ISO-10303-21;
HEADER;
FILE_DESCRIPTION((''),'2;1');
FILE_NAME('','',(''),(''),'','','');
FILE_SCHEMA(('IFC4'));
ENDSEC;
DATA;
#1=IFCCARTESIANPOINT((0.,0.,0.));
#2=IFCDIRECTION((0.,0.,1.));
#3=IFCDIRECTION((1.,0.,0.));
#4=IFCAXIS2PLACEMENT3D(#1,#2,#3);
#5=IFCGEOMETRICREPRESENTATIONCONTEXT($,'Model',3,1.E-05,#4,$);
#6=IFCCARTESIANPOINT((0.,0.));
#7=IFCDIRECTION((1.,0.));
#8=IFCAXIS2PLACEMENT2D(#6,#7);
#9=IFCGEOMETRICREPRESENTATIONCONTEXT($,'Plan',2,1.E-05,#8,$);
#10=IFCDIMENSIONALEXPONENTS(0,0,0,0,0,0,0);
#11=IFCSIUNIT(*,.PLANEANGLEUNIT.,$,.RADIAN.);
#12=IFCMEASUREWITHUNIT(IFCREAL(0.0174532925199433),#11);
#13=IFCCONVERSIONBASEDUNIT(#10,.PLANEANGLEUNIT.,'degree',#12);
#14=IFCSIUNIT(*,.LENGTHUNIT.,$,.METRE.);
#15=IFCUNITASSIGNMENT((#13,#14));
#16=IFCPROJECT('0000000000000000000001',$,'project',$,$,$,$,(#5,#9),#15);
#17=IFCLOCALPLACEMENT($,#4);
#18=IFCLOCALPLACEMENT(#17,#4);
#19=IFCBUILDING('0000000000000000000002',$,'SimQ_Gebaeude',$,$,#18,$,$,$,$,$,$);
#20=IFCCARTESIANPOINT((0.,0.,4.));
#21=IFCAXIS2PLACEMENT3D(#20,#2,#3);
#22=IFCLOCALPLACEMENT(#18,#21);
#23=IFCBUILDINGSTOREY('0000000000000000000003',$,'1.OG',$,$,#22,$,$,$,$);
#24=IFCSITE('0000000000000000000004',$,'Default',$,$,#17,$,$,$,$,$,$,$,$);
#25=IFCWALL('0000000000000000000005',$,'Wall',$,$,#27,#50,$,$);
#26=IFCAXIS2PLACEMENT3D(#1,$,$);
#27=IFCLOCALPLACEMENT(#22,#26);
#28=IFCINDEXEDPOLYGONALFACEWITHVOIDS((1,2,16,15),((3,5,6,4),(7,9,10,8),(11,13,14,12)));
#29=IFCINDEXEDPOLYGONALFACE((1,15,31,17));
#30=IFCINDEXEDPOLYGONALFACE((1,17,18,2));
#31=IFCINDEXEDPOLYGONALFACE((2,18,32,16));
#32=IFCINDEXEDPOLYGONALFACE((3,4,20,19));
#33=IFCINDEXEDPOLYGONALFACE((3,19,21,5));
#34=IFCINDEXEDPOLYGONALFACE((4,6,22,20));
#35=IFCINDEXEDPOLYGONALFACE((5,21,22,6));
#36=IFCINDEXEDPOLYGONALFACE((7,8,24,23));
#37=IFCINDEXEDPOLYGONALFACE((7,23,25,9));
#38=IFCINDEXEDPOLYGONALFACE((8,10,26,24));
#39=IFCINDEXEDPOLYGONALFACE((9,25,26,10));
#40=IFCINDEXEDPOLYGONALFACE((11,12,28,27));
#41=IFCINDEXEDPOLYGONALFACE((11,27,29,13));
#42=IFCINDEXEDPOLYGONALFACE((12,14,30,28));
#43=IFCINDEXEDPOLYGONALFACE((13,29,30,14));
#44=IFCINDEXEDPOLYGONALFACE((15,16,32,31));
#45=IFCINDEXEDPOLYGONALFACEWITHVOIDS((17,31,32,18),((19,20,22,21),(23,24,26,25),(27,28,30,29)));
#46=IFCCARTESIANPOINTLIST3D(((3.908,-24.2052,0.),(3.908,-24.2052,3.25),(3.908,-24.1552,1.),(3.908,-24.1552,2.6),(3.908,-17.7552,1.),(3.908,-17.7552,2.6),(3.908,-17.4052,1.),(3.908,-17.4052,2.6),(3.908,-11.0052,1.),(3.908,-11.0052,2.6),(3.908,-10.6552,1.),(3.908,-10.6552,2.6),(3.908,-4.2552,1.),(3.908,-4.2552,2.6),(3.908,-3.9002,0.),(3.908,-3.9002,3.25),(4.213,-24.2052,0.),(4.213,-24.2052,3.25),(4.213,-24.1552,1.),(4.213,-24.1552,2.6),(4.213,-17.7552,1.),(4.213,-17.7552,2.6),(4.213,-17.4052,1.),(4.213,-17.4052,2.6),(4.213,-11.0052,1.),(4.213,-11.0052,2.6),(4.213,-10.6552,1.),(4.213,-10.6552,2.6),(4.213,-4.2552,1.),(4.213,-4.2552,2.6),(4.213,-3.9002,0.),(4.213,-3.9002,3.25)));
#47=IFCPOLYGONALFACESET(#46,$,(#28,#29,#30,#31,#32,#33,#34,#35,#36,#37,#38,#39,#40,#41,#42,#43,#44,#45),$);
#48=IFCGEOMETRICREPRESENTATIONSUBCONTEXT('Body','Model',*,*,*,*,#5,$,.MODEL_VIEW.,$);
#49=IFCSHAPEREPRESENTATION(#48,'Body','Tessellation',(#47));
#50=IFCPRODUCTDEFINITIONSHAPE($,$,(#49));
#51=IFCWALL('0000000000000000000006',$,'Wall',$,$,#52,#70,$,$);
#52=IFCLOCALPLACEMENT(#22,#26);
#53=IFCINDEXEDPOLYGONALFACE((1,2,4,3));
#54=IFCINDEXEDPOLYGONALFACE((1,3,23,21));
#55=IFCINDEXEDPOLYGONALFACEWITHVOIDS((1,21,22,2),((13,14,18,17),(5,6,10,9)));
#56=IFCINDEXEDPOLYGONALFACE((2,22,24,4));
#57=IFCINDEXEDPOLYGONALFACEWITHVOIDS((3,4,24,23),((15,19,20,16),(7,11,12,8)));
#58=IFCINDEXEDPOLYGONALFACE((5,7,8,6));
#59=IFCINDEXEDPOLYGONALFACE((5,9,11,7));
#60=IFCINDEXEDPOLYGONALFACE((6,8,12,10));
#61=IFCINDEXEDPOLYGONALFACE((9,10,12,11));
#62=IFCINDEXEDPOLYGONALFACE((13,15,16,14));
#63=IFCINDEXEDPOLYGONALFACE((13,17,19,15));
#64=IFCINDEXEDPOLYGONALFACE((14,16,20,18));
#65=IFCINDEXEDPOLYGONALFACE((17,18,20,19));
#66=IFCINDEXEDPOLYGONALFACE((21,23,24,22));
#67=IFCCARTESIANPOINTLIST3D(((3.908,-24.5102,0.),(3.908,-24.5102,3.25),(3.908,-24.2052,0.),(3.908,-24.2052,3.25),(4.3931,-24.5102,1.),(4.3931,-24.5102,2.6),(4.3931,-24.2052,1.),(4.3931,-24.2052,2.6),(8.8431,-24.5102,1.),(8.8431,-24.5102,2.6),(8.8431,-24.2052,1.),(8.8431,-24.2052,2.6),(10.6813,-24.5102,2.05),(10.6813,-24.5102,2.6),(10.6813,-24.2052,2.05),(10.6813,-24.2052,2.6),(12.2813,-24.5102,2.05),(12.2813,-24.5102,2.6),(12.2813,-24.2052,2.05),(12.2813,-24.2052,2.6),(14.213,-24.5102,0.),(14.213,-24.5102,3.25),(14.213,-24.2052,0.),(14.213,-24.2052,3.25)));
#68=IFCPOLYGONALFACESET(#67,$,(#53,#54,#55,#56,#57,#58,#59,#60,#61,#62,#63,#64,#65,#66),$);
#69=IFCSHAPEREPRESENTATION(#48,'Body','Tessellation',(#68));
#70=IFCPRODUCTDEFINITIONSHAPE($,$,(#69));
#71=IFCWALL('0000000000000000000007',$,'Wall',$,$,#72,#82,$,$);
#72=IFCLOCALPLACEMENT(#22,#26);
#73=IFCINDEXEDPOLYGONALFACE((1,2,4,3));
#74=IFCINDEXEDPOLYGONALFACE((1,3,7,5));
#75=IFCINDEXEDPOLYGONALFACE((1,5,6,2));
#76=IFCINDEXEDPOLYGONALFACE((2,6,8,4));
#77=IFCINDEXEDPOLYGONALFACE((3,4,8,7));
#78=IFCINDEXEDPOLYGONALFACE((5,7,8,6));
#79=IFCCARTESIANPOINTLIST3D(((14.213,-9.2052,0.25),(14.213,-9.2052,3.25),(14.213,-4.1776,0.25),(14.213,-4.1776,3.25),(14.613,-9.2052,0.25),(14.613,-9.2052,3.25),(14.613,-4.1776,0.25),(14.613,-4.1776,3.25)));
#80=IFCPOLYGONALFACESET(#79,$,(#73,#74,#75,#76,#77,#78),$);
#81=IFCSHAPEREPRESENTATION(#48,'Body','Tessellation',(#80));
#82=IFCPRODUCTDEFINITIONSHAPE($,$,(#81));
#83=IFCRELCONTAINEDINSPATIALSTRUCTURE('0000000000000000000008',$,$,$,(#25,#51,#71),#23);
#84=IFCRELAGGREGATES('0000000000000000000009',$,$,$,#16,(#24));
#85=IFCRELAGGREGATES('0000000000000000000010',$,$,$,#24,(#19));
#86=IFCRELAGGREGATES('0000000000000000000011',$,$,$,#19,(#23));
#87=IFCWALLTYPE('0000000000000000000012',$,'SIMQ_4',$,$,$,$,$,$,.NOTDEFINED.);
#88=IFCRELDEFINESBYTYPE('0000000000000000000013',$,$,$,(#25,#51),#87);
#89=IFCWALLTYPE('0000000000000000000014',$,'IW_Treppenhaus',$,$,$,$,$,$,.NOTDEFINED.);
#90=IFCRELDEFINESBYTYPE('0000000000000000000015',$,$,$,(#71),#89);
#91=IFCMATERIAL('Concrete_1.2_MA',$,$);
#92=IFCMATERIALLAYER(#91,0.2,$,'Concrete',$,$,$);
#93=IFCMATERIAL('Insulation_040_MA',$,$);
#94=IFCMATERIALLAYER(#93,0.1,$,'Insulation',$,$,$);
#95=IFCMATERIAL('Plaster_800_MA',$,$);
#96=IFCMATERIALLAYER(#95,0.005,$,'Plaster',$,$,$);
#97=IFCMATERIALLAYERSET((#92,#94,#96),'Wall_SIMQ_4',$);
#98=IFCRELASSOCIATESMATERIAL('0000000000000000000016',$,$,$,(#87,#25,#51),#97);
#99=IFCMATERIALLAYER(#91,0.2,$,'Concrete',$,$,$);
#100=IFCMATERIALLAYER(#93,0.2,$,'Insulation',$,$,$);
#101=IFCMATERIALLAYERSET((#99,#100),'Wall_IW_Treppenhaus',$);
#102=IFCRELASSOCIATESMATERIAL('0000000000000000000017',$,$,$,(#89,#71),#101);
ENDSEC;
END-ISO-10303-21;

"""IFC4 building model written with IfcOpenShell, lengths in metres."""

from ifc_helpers import new_model, entity, si_unit, converted_unit, frame, origin_with_axes, origin_2d_with_axis, place, context, subcontext, project, spatial, line, indexed_curve, outline, extrude, source, transform, mapped, material, layer, layer_set, layer_usage, type_object, element, save


model = new_model("IFC4")

# Units and contexts
model_context = context("Model", 3, precision=1e-05, world=origin_with_axes())
plan_context = context("Plan", 2, precision=1e-05, world=origin_2d_with_axis())
body_context = subcontext(model_context, "Body", "Model", "MODEL_VIEW")
ifc_project = project(units=[converted_unit("PLANEANGLEUNIT", "degree", entity("IfcReal", 0.0174532925199433), si_unit("PLANEANGLEUNIT", "RADIAN"), dimensions=[0, 0, 0, 0, 0, 0, 0]), si_unit("LENGTHUNIT", "METRE")], contexts=[model_context, plan_context])

# Site, building, storey
site_placement = place(None, origin_with_axes())
site = spatial("IfcSite", under=ifc_project, at=site_placement, Name="Default")
building_placement = place(site_placement, origin_with_axes())
building = spatial("IfcBuilding", under=site, at=building_placement, Name="SimQ_Gebaeude")
storey_placement = place(building_placement, frame((0.0, 0.0, 4.0), z_axis=(0.0, 0.0, 1.0), x_axis=(1.0, 0.0, 0.0)))
storey = spatial("IfcBuildingStorey", under=building, at=storey_placement, Name="1.OG")

# Shared definitions
ifc_material_1 = material(Name="Insulation_040_MA")
ifc_material_2 = material(Name="Concrete_1.2_MA")

# Walls, openings
ifc_layer_1 = layer(ifc_material_2, 0.2, Name="Concrete")
ifc_layer_2 = layer(ifc_material_1, 0.1, Name="Insulation")
ifc_material_3 = material(Name="Plaster_800_MA")
ifc_layer_3 = layer(ifc_material_3, 0.005, Name="Plaster")
ifc_layer_set_1 = layer_set([ifc_layer_1, ifc_layer_2, ifc_layer_3], Name="Wall_SIMQ_4")
wall_type_1 = type_object("IfcWallType", Name="SIMQ_4", PredefinedType="NOTDEFINED", material=ifc_layer_set_1)
shared_shape_1 = source(origin_with_axes(), body_context, "Body", "SweptSolid", [
    extrude(outline(indexed_curve([(0.0, 0.0), (1.6, 0.0), (1.6, 0.55), (0.0, 0.55)], segments=[line(1, 2, 3, 4, 1)])), frame((0.0, -0.6, 0.0), z_axis=(0.0, -1.0, 0.0), x_axis=(1.0, 0.0, 0.0)), (0.0, 0.0, -1.0), 1.2),
])
shared_shape_2 = source(origin_with_axes(), body_context, "Body", "SweptSolid", [
    extrude(outline(indexed_curve([(0.0, 0.0), (4.45, 0.0), (4.45, 1.6), (0.0, 1.6)], segments=[line(1, 2, 3, 4, 1)])), frame((0.0, -0.6, 0.0), z_axis=(0.0, -1.0, 0.0), x_axis=(1.0, 0.0, 0.0)), (0.0, 0.0, -1.0), 1.2),
])
ifc_layer_usage_1 = layer_usage(ifc_layer_set_1, "AXIS2", "POSITIVE", 0.0)
wall_1_placement = place(storey_placement, frame((3.908, -3.9002, 0.0), z_axis=(0.0, 0.0, 1.0), x_axis=(-0.000001, -1.0, 0.0)))
wall_1 = element("IfcWall", 1, at=wall_1_placement, inside=storey, type_object=wall_type_1, material=ifc_layer_usage_1, Name="Wall", context=body_context, shape_type="SweptSolid", body=[
    extrude(outline(indexed_curve([(0.0, 0.0), (0.0, 0.305), (20.305, 0.305), (20.305, 0.0), (0.0, 0.0)], self_intersect=False)), origin_with_axes(), (0.0, 0.0, 1.0), 3.25),
])
shared_shape_3 = source(origin_with_axes(), body_context, "Body", "SweptSolid", [
    extrude(outline(indexed_curve([(0.0, 0.0), (6.4, 0.0), (6.4, 1.6), (0.0, 1.6)], segments=[line(1, 2, 3, 4, 1)])), frame((0.0, -0.6, 0.0), z_axis=(0.0, -1.0, 0.0), x_axis=(1.0, 0.0, 0.0)), (0.0, 0.0, -1.0), 1.2),
])
opening_1_placement = place(wall_1_placement, frame((0.355, 0.0, 1.0), z_axis=(0.0, 0.0, 1.0), x_axis=(1.0, 0.0, 0.0)))
element("IfcOpeningElement", 2, at=opening_1_placement, cuts=wall_1, PredefinedType="OPENING", context=body_context, shape_type="MappedRepresentation", body=[
    mapped(shared_shape_3, transform((0.0, 0.0, 0.0), x_axis=(1.0, 0.0, 0.0), y_axis=(0.0, 1.0, 0.0), z_axis=(0.0, 0.0, 1.0), scale=1.0)),
])
opening_2_placement = place(wall_1_placement, frame((7.105, 0.0, 1.0), z_axis=(0.0, 0.0, 1.0), x_axis=(1.0, 0.0, 0.0)))
element("IfcOpeningElement", 3, at=opening_2_placement, cuts=wall_1, PredefinedType="OPENING", context=body_context, shape_type="MappedRepresentation", body=[
    mapped(shared_shape_3, transform((0.0, 0.0, 0.0), x_axis=(1.0, 0.0, 0.0), y_axis=(0.0, 1.0, 0.0), z_axis=(0.0, 0.0, 1.0), scale=1.0)),
])
opening_3_placement = place(wall_1_placement, frame((13.855, 0.0, 1.0), z_axis=(0.0, 0.0, 1.0), x_axis=(1.0, 0.0, 0.0)))
element("IfcOpeningElement", 4, at=opening_3_placement, cuts=wall_1, PredefinedType="OPENING", context=body_context, shape_type="MappedRepresentation", body=[
    mapped(shared_shape_3, transform((0.0, 0.0, 0.0), x_axis=(1.0, 0.0, 0.0), y_axis=(0.0, 1.0, 0.0), z_axis=(0.0, 0.0, 1.0), scale=1.0)),
])
ifc_layer_usage_2 = layer_usage(ifc_layer_set_1, "AXIS2", "POSITIVE", 0.0)
wall_2_placement = place(storey_placement, frame((3.908, -24.5102, 0.0), z_axis=(0.0, 0.0, 1.0), x_axis=(1.0, -0.000001, 0.0)))
wall_2 = element("IfcWall", 5, at=wall_2_placement, inside=storey, type_object=wall_type_1, material=ifc_layer_usage_2, Name="Wall", context=body_context, shape_type="SweptSolid", body=[
    extrude(outline(indexed_curve([(0.0, 0.0), (0.0, 0.305), (10.305, 0.305), (10.305, 0.0), (0.0, 0.0)], self_intersect=False)), origin_with_axes(), (0.0, 0.0, 1.0), 3.25),
])
opening_4_placement = place(wall_2_placement, frame((0.4851, 0.0, 1.0), z_axis=(0.0, 0.0, 1.0), x_axis=(1.0, 0.0, 0.0)))
element("IfcOpeningElement", 6, at=opening_4_placement, cuts=wall_2, PredefinedType="OPENING", context=body_context, shape_type="MappedRepresentation", body=[
    mapped(shared_shape_2, transform((0.0, 0.0, 0.0), x_axis=(1.0, 0.0, 0.0), y_axis=(0.0, 1.0, 0.0), z_axis=(0.0, 0.0, 1.0), scale=1.0)),
])
opening_5_placement = place(wall_2_placement, frame((6.7732, 0.0, 2.05), z_axis=(0.0, 0.0, 1.0), x_axis=(1.0, 0.0, 0.0)))
element("IfcOpeningElement", 7, at=opening_5_placement, cuts=wall_2, PredefinedType="OPENING", context=body_context, shape_type="MappedRepresentation", body=[
    mapped(shared_shape_1, transform((0.0, 0.0, 0.0), x_axis=(1.0, 0.0, 0.0), y_axis=(0.0, 1.0, 0.0), z_axis=(0.0, 0.0, 1.0), scale=1.0)),
])

# Wall
ifc_layer_4 = layer(ifc_material_2, 0.2, Name="Concrete")
ifc_layer_5 = layer(ifc_material_1, 0.2, Name="Insulation")
ifc_layer_set_2 = layer_set([ifc_layer_4, ifc_layer_5], Name="Wall_IW_Treppenhaus")
ifc_layer_usage_3 = layer_usage(ifc_layer_set_2, "AXIS2", "POSITIVE", 0.0)
wall_type_2 = type_object("IfcWallType", Name="IW_Treppenhaus", PredefinedType="NOTDEFINED", material=ifc_layer_set_2)
wall_3_placement = place(storey_placement, frame((14.213, -4.1776, 0.25), z_axis=(0.0, 0.0, 1.0), x_axis=(-0.000001, -1.0, 0.0)))
element("IfcWall", 8, at=wall_3_placement, inside=storey, type_object=wall_type_2, material=ifc_layer_usage_3, Name="Wall", context=body_context, shape_type="SweptSolid", body=[
    extrude(outline(indexed_curve([(0.0, 0.0), (0.0, 0.4), (5.0276, 0.4), (5.0276, 0.0), (0.0, 0.0)], self_intersect=False)), origin_with_axes(), (0.0, 0.0, 1.0), 3.0),
])

save(model, "model.ifc")
